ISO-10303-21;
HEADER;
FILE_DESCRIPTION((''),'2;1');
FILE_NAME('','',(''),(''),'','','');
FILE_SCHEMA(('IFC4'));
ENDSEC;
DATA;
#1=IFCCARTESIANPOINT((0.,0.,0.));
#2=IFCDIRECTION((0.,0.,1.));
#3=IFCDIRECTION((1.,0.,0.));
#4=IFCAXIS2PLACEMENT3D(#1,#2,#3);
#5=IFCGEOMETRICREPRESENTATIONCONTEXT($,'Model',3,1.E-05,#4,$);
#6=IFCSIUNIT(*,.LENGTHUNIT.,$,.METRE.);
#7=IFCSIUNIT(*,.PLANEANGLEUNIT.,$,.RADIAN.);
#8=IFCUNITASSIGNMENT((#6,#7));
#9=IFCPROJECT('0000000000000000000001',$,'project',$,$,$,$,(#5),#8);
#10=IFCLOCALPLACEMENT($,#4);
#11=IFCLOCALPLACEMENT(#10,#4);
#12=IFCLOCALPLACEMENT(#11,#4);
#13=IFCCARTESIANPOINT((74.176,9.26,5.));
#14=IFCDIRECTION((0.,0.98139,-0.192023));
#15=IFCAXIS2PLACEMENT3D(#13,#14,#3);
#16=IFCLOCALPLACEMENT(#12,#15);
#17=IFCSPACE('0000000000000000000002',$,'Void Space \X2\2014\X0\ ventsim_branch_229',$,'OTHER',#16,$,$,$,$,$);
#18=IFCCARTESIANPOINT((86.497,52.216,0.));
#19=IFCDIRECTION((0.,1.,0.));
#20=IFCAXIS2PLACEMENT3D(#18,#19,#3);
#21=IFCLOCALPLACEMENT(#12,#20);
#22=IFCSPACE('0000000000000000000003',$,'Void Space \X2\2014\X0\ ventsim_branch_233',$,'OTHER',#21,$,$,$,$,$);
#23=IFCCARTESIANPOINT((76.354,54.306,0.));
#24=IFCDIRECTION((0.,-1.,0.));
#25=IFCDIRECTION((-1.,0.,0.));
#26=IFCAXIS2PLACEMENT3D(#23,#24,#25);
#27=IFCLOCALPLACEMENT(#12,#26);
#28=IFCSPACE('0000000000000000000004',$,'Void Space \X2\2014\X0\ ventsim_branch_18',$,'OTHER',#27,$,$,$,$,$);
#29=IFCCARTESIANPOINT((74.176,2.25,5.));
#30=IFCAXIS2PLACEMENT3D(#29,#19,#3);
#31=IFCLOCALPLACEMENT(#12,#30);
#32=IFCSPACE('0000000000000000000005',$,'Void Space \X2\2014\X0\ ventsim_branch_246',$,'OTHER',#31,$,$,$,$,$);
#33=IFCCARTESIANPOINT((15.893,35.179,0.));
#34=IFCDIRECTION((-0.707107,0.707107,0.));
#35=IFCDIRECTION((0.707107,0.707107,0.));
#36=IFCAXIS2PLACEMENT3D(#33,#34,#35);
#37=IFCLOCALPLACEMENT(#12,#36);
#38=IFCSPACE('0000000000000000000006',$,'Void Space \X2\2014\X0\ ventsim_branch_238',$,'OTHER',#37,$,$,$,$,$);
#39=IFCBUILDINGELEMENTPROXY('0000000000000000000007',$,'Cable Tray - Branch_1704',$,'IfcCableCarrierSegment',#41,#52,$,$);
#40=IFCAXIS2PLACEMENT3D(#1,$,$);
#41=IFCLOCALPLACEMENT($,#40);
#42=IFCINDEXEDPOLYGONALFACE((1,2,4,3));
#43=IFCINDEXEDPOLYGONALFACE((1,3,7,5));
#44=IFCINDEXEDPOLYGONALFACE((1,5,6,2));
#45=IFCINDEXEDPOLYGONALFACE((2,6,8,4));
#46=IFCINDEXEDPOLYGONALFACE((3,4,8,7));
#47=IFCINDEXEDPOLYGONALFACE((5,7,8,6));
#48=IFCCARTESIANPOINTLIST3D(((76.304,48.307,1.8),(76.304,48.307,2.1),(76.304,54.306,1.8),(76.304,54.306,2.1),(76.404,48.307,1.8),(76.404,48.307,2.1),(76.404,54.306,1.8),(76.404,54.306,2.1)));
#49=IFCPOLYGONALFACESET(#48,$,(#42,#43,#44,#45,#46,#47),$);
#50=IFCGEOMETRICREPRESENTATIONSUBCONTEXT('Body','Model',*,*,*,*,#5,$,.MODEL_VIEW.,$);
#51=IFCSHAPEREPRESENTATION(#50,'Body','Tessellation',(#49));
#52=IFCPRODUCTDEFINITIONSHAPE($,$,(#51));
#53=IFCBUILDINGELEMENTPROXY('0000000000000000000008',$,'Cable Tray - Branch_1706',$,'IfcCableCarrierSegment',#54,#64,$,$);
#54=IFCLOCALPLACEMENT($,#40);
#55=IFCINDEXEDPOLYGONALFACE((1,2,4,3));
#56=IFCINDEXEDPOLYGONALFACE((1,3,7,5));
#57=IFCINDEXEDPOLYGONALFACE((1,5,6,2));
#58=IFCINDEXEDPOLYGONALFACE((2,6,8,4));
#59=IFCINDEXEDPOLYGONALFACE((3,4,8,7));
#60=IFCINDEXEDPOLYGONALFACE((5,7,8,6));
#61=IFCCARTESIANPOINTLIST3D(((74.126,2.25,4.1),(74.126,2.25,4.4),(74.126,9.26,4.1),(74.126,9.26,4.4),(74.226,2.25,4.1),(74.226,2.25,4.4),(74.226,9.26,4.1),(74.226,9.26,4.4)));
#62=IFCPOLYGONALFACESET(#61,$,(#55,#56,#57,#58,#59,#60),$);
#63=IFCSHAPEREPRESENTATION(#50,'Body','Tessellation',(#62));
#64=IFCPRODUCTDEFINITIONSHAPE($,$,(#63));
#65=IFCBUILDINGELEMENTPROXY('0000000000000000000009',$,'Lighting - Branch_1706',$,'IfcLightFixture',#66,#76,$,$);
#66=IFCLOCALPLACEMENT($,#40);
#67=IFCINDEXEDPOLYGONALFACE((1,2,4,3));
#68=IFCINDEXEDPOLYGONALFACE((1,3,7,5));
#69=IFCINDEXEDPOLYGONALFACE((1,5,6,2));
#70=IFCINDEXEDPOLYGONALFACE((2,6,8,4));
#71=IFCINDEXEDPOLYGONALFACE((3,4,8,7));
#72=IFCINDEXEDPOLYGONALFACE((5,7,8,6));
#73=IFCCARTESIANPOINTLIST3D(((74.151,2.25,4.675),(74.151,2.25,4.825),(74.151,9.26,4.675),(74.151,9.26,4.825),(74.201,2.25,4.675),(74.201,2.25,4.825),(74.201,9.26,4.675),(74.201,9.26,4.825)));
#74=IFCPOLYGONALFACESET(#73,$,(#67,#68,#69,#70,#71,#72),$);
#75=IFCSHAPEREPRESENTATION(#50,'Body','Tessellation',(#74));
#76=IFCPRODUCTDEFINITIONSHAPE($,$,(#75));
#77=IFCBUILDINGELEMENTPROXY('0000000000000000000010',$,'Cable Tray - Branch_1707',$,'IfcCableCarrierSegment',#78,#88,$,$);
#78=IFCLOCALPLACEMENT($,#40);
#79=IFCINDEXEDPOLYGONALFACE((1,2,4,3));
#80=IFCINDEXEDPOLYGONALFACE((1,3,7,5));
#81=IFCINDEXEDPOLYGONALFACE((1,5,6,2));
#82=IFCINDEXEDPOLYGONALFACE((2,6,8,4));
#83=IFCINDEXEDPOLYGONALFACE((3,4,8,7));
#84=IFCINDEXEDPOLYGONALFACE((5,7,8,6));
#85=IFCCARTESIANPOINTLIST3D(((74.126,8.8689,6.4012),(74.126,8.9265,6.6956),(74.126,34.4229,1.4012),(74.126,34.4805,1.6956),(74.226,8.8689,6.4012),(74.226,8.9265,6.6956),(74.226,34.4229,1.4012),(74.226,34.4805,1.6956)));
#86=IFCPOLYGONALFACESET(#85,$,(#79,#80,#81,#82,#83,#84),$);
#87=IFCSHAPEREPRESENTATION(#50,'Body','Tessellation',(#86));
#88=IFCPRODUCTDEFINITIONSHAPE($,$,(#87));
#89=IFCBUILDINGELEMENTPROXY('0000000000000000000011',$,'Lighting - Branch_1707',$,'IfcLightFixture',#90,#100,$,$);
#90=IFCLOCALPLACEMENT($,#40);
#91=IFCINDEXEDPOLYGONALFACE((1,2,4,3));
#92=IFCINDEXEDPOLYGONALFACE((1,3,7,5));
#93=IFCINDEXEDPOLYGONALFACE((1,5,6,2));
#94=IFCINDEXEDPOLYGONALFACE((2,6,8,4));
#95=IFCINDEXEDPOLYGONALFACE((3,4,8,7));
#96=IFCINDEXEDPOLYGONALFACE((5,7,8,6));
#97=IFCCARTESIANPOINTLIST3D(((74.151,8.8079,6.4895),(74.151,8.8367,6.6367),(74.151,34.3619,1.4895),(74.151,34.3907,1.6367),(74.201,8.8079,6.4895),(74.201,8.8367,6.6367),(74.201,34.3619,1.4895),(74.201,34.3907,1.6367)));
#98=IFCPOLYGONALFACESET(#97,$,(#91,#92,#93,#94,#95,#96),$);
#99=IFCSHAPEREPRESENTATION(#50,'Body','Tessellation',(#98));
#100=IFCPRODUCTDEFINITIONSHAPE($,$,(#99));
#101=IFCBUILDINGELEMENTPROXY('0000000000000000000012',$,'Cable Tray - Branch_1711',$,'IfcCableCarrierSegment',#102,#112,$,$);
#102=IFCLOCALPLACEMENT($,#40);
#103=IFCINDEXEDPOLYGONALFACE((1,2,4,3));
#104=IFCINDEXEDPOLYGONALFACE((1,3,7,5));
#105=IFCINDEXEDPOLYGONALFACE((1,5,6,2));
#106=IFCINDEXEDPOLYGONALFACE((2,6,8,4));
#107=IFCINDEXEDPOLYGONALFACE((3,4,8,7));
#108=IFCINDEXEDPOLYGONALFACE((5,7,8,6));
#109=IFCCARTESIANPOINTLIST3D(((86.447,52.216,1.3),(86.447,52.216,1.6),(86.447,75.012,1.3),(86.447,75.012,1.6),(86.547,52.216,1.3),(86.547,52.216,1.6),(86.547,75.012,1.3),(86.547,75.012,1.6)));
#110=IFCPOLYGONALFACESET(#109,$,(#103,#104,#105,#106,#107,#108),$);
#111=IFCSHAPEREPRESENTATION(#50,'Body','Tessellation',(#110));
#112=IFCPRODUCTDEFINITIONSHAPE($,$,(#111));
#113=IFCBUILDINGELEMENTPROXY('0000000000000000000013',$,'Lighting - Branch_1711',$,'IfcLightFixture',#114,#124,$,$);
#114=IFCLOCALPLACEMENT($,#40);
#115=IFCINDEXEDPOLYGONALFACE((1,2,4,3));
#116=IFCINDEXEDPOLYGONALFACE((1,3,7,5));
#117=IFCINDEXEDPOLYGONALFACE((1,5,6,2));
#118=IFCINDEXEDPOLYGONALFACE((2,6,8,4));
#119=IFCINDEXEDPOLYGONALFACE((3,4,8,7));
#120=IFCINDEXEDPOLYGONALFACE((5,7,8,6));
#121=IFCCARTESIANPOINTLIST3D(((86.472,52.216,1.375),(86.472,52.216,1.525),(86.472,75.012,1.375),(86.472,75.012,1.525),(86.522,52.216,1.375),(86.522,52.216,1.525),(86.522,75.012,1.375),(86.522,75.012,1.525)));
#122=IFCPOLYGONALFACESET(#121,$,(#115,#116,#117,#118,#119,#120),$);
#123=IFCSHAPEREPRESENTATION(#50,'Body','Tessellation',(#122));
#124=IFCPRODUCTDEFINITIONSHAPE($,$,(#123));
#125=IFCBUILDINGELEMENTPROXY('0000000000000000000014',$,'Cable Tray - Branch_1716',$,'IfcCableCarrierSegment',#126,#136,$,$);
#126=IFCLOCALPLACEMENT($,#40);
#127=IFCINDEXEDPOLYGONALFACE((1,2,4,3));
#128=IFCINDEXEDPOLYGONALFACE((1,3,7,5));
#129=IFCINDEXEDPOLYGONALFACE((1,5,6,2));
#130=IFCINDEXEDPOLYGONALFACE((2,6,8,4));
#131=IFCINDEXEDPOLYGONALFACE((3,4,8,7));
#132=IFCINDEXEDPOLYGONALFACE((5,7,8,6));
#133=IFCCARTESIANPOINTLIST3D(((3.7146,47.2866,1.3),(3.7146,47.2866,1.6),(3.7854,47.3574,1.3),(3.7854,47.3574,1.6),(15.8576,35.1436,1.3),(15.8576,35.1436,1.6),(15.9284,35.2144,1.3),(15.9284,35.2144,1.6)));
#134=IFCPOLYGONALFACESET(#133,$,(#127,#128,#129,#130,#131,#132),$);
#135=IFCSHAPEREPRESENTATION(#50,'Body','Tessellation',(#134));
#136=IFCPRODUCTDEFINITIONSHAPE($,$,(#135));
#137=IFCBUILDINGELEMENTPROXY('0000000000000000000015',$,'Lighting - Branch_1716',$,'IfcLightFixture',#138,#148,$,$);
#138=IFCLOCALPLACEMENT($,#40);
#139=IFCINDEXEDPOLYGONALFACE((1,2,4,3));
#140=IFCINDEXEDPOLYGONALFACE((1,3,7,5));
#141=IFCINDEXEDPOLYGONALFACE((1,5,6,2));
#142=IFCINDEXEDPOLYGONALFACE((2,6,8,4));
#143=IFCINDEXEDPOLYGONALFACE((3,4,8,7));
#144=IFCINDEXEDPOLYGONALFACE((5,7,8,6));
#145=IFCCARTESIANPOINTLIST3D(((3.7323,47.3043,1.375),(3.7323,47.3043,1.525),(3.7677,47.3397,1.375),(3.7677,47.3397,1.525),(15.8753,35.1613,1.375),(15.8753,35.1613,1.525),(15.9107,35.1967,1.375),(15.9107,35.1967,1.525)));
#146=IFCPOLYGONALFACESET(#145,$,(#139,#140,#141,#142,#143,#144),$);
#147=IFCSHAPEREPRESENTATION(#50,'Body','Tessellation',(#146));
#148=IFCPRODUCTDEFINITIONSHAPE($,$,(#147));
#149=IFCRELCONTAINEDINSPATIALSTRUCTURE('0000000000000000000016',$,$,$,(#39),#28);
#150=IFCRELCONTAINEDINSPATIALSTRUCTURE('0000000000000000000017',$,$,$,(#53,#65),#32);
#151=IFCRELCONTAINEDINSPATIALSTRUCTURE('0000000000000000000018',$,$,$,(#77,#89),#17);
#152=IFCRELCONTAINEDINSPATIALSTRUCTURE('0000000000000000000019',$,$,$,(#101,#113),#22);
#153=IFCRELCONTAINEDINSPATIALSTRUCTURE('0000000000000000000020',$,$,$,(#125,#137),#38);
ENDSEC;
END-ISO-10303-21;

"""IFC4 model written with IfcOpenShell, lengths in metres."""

from ifc_helpers import new_model, si_unit, frame, origin_with_axes, origin_2d_with_axis, place, context, subcontext, project, spatial, rectangle, extrude, element, save


model = new_model("IFC4")

# Units and contexts
model_context = context("Model", 3, precision=1e-05, world=origin_with_axes())
body_context = subcontext(model_context, "Body", "Model", "MODEL_VIEW")
ifc_project = project(units=[si_unit("LENGTHUNIT", "METRE"), si_unit("PLANEANGLEUNIT", "RADIAN")], contexts=[model_context])

# Shared definitions
placement_1 = place(None, origin_with_axes())
placement_2 = place(placement_1, origin_with_axes())
placement_3 = place(placement_2, origin_with_axes())

# Shared definitions
space_1_placement = place(placement_3, frame((74.176, 9.26, 5.0), z_axis=(0.0, 0.98139, -0.192023), x_axis=(1.0, 0.0, 0.0)))
space_1 = spatial("IfcSpace", at=space_1_placement, Name="Void Space — ventsim_branch_229", ObjectType="OTHER")

# Shared definitions
space_2_placement = place(placement_3, frame((86.497, 52.216, 0.0), z_axis=(0.0, 1.0, 0.0), x_axis=(1.0, 0.0, 0.0)))
space_2 = spatial("IfcSpace", at=space_2_placement, Name="Void Space — ventsim_branch_233", ObjectType="OTHER")

# Shared definitions
space_3_placement = place(placement_3, frame((76.354, 54.306, 0.0), z_axis=(0.0, -1.0, 0.0), x_axis=(-1.0, 0.0, 0.0)))
space_3 = spatial("IfcSpace", at=space_3_placement, Name="Void Space — ventsim_branch_18", ObjectType="OTHER")

# Building element proxy
proxy_1_placement = place(placement_3, frame((76.354, 54.306, 1.95), z_axis=(0.0, -1.0, 0.0), x_axis=(0.0, 0.0, 1.0)))
element("IfcBuildingElementProxy", 1, at=proxy_1_placement, inside=space_3, Name="Cable Tray - Branch_1704", ObjectType="IfcCableCarrierSegment", context=body_context, shape_type="SweptSolid", body=[
    extrude(rectangle(XDim=0.3, YDim=0.1, at=origin_2d_with_axis()), origin_with_axes(), (0.0, 0.0, 1.0), 5.999),
])

# Shared definitions
space_4_placement = place(placement_3, frame((74.176, 2.25, 5.0), z_axis=(0.0, 1.0, 0.0), x_axis=(1.0, 0.0, 0.0)))
space_4 = spatial("IfcSpace", at=space_4_placement, Name="Void Space — ventsim_branch_246", ObjectType="OTHER")

# Building element proxies
proxy_2_placement = place(placement_3, frame((74.176, 2.25, 4.25), z_axis=(0.0, 1.0, 0.0), x_axis=(0.0, 0.0, 1.0)))
element("IfcBuildingElementProxy", 2, at=proxy_2_placement, inside=space_4, Name="Cable Tray - Branch_1706", ObjectType="IfcCableCarrierSegment", context=body_context, shape_type="SweptSolid", body=[
    extrude(rectangle(XDim=0.3, YDim=0.1, at=origin_2d_with_axis()), origin_with_axes(), (0.0, 0.0, 1.0), 7.01),
])
proxy_3_placement = place(placement_3, frame((74.176, 2.25, 4.75), z_axis=(0.0, 1.0, 0.0), x_axis=(0.0, 0.0, 1.0)))
element("IfcBuildingElementProxy", 3, at=proxy_3_placement, inside=space_4, Name="Lighting - Branch_1706", ObjectType="IfcLightFixture", context=body_context, shape_type="SweptSolid", body=[
    extrude(rectangle(XDim=0.15, YDim=0.05, at=origin_2d_with_axis()), origin_with_axes(), (0.0, 0.0, 1.0), 7.01),
])
proxy_4_placement = place(placement_3, frame((74.176, 8.8977, 6.5484), z_axis=(0.0, 0.98139, -0.192023), x_axis=(0.0, 0.192023, 0.98139)))
element("IfcBuildingElementProxy", 4, at=proxy_4_placement, inside=space_1, Name="Cable Tray - Branch_1707", ObjectType="IfcCableCarrierSegment", context=body_context, shape_type="SweptSolid", body=[
    extrude(rectangle(XDim=0.3, YDim=0.1, at=origin_2d_with_axis()), origin_with_axes(), (0.0, 0.0, 1.0), 26.0386),
])
proxy_5_placement = place(placement_3, frame((74.176, 8.8223, 6.5631), z_axis=(0.0, 0.98139, -0.192023), x_axis=(0.0, 0.192023, 0.98139)))
element("IfcBuildingElementProxy", 5, at=proxy_5_placement, inside=space_1, Name="Lighting - Branch_1707", ObjectType="IfcLightFixture", context=body_context, shape_type="SweptSolid", body=[
    extrude(rectangle(XDim=0.15, YDim=0.05, at=origin_2d_with_axis()), origin_with_axes(), (0.0, 0.0, 1.0), 26.0386),
])
proxy_6_placement = place(placement_3, frame((86.497, 52.216, 1.45), z_axis=(0.0, 1.0, 0.0), x_axis=(0.0, 0.0, 1.0)))
element("IfcBuildingElementProxy", 6, at=proxy_6_placement, inside=space_2, Name="Cable Tray - Branch_1711", ObjectType="IfcCableCarrierSegment", context=body_context, shape_type="SweptSolid", body=[
    extrude(rectangle(XDim=0.3, YDim=0.1, at=origin_2d_with_axis()), origin_with_axes(), (0.0, 0.0, 1.0), 22.796),
])
proxy_7_placement = place(placement_3, frame((86.497, 52.216, 1.45), z_axis=(0.0, 1.0, 0.0), x_axis=(0.0, 0.0, 1.0)))
element("IfcBuildingElementProxy", 7, at=proxy_7_placement, inside=space_2, Name="Lighting - Branch_1711", ObjectType="IfcLightFixture", context=body_context, shape_type="SweptSolid", body=[
    extrude(rectangle(XDim=0.15, YDim=0.05, at=origin_2d_with_axis()), origin_with_axes(), (0.0, 0.0, 1.0), 22.796),
])

# Shared definitions
space_5_placement = place(placement_3, frame((15.893, 35.179, 0.0), z_axis=(-0.707107, 0.707107, 0.0), x_axis=(0.707107, 0.707107, 0.0)))
space_5 = spatial("IfcSpace", at=space_5_placement, Name="Void Space — ventsim_branch_238", ObjectType="OTHER")

# Building element proxies
proxy_8_placement = place(placement_3, frame((15.893, 35.179, 1.45), z_axis=(-0.707107, 0.707107, 0.0), x_axis=(0.0, 0.0, 1.0)))
element("IfcBuildingElementProxy", 8, at=proxy_8_placement, inside=space_5, Name="Cable Tray - Branch_1716", ObjectType="IfcCableCarrierSegment", context=body_context, shape_type="SweptSolid", body=[
    extrude(rectangle(XDim=0.3, YDim=0.1, at=origin_2d_with_axis()), origin_with_axes(), (0.0, 0.0, 1.0), 17.1728),
])
proxy_9_placement = place(placement_3, frame((15.893, 35.179, 1.45), z_axis=(-0.707107, 0.707107, 0.0), x_axis=(0.0, 0.0, 1.0)))
element("IfcBuildingElementProxy", 9, at=proxy_9_placement, inside=space_5, Name="Lighting - Branch_1716", ObjectType="IfcLightFixture", context=body_context, shape_type="SweptSolid", body=[
    extrude(rectangle(XDim=0.15, YDim=0.05, at=origin_2d_with_axis()), origin_with_axes(), (0.0, 0.0, 1.0), 17.1728),
])

save(model, "model.ifc")
